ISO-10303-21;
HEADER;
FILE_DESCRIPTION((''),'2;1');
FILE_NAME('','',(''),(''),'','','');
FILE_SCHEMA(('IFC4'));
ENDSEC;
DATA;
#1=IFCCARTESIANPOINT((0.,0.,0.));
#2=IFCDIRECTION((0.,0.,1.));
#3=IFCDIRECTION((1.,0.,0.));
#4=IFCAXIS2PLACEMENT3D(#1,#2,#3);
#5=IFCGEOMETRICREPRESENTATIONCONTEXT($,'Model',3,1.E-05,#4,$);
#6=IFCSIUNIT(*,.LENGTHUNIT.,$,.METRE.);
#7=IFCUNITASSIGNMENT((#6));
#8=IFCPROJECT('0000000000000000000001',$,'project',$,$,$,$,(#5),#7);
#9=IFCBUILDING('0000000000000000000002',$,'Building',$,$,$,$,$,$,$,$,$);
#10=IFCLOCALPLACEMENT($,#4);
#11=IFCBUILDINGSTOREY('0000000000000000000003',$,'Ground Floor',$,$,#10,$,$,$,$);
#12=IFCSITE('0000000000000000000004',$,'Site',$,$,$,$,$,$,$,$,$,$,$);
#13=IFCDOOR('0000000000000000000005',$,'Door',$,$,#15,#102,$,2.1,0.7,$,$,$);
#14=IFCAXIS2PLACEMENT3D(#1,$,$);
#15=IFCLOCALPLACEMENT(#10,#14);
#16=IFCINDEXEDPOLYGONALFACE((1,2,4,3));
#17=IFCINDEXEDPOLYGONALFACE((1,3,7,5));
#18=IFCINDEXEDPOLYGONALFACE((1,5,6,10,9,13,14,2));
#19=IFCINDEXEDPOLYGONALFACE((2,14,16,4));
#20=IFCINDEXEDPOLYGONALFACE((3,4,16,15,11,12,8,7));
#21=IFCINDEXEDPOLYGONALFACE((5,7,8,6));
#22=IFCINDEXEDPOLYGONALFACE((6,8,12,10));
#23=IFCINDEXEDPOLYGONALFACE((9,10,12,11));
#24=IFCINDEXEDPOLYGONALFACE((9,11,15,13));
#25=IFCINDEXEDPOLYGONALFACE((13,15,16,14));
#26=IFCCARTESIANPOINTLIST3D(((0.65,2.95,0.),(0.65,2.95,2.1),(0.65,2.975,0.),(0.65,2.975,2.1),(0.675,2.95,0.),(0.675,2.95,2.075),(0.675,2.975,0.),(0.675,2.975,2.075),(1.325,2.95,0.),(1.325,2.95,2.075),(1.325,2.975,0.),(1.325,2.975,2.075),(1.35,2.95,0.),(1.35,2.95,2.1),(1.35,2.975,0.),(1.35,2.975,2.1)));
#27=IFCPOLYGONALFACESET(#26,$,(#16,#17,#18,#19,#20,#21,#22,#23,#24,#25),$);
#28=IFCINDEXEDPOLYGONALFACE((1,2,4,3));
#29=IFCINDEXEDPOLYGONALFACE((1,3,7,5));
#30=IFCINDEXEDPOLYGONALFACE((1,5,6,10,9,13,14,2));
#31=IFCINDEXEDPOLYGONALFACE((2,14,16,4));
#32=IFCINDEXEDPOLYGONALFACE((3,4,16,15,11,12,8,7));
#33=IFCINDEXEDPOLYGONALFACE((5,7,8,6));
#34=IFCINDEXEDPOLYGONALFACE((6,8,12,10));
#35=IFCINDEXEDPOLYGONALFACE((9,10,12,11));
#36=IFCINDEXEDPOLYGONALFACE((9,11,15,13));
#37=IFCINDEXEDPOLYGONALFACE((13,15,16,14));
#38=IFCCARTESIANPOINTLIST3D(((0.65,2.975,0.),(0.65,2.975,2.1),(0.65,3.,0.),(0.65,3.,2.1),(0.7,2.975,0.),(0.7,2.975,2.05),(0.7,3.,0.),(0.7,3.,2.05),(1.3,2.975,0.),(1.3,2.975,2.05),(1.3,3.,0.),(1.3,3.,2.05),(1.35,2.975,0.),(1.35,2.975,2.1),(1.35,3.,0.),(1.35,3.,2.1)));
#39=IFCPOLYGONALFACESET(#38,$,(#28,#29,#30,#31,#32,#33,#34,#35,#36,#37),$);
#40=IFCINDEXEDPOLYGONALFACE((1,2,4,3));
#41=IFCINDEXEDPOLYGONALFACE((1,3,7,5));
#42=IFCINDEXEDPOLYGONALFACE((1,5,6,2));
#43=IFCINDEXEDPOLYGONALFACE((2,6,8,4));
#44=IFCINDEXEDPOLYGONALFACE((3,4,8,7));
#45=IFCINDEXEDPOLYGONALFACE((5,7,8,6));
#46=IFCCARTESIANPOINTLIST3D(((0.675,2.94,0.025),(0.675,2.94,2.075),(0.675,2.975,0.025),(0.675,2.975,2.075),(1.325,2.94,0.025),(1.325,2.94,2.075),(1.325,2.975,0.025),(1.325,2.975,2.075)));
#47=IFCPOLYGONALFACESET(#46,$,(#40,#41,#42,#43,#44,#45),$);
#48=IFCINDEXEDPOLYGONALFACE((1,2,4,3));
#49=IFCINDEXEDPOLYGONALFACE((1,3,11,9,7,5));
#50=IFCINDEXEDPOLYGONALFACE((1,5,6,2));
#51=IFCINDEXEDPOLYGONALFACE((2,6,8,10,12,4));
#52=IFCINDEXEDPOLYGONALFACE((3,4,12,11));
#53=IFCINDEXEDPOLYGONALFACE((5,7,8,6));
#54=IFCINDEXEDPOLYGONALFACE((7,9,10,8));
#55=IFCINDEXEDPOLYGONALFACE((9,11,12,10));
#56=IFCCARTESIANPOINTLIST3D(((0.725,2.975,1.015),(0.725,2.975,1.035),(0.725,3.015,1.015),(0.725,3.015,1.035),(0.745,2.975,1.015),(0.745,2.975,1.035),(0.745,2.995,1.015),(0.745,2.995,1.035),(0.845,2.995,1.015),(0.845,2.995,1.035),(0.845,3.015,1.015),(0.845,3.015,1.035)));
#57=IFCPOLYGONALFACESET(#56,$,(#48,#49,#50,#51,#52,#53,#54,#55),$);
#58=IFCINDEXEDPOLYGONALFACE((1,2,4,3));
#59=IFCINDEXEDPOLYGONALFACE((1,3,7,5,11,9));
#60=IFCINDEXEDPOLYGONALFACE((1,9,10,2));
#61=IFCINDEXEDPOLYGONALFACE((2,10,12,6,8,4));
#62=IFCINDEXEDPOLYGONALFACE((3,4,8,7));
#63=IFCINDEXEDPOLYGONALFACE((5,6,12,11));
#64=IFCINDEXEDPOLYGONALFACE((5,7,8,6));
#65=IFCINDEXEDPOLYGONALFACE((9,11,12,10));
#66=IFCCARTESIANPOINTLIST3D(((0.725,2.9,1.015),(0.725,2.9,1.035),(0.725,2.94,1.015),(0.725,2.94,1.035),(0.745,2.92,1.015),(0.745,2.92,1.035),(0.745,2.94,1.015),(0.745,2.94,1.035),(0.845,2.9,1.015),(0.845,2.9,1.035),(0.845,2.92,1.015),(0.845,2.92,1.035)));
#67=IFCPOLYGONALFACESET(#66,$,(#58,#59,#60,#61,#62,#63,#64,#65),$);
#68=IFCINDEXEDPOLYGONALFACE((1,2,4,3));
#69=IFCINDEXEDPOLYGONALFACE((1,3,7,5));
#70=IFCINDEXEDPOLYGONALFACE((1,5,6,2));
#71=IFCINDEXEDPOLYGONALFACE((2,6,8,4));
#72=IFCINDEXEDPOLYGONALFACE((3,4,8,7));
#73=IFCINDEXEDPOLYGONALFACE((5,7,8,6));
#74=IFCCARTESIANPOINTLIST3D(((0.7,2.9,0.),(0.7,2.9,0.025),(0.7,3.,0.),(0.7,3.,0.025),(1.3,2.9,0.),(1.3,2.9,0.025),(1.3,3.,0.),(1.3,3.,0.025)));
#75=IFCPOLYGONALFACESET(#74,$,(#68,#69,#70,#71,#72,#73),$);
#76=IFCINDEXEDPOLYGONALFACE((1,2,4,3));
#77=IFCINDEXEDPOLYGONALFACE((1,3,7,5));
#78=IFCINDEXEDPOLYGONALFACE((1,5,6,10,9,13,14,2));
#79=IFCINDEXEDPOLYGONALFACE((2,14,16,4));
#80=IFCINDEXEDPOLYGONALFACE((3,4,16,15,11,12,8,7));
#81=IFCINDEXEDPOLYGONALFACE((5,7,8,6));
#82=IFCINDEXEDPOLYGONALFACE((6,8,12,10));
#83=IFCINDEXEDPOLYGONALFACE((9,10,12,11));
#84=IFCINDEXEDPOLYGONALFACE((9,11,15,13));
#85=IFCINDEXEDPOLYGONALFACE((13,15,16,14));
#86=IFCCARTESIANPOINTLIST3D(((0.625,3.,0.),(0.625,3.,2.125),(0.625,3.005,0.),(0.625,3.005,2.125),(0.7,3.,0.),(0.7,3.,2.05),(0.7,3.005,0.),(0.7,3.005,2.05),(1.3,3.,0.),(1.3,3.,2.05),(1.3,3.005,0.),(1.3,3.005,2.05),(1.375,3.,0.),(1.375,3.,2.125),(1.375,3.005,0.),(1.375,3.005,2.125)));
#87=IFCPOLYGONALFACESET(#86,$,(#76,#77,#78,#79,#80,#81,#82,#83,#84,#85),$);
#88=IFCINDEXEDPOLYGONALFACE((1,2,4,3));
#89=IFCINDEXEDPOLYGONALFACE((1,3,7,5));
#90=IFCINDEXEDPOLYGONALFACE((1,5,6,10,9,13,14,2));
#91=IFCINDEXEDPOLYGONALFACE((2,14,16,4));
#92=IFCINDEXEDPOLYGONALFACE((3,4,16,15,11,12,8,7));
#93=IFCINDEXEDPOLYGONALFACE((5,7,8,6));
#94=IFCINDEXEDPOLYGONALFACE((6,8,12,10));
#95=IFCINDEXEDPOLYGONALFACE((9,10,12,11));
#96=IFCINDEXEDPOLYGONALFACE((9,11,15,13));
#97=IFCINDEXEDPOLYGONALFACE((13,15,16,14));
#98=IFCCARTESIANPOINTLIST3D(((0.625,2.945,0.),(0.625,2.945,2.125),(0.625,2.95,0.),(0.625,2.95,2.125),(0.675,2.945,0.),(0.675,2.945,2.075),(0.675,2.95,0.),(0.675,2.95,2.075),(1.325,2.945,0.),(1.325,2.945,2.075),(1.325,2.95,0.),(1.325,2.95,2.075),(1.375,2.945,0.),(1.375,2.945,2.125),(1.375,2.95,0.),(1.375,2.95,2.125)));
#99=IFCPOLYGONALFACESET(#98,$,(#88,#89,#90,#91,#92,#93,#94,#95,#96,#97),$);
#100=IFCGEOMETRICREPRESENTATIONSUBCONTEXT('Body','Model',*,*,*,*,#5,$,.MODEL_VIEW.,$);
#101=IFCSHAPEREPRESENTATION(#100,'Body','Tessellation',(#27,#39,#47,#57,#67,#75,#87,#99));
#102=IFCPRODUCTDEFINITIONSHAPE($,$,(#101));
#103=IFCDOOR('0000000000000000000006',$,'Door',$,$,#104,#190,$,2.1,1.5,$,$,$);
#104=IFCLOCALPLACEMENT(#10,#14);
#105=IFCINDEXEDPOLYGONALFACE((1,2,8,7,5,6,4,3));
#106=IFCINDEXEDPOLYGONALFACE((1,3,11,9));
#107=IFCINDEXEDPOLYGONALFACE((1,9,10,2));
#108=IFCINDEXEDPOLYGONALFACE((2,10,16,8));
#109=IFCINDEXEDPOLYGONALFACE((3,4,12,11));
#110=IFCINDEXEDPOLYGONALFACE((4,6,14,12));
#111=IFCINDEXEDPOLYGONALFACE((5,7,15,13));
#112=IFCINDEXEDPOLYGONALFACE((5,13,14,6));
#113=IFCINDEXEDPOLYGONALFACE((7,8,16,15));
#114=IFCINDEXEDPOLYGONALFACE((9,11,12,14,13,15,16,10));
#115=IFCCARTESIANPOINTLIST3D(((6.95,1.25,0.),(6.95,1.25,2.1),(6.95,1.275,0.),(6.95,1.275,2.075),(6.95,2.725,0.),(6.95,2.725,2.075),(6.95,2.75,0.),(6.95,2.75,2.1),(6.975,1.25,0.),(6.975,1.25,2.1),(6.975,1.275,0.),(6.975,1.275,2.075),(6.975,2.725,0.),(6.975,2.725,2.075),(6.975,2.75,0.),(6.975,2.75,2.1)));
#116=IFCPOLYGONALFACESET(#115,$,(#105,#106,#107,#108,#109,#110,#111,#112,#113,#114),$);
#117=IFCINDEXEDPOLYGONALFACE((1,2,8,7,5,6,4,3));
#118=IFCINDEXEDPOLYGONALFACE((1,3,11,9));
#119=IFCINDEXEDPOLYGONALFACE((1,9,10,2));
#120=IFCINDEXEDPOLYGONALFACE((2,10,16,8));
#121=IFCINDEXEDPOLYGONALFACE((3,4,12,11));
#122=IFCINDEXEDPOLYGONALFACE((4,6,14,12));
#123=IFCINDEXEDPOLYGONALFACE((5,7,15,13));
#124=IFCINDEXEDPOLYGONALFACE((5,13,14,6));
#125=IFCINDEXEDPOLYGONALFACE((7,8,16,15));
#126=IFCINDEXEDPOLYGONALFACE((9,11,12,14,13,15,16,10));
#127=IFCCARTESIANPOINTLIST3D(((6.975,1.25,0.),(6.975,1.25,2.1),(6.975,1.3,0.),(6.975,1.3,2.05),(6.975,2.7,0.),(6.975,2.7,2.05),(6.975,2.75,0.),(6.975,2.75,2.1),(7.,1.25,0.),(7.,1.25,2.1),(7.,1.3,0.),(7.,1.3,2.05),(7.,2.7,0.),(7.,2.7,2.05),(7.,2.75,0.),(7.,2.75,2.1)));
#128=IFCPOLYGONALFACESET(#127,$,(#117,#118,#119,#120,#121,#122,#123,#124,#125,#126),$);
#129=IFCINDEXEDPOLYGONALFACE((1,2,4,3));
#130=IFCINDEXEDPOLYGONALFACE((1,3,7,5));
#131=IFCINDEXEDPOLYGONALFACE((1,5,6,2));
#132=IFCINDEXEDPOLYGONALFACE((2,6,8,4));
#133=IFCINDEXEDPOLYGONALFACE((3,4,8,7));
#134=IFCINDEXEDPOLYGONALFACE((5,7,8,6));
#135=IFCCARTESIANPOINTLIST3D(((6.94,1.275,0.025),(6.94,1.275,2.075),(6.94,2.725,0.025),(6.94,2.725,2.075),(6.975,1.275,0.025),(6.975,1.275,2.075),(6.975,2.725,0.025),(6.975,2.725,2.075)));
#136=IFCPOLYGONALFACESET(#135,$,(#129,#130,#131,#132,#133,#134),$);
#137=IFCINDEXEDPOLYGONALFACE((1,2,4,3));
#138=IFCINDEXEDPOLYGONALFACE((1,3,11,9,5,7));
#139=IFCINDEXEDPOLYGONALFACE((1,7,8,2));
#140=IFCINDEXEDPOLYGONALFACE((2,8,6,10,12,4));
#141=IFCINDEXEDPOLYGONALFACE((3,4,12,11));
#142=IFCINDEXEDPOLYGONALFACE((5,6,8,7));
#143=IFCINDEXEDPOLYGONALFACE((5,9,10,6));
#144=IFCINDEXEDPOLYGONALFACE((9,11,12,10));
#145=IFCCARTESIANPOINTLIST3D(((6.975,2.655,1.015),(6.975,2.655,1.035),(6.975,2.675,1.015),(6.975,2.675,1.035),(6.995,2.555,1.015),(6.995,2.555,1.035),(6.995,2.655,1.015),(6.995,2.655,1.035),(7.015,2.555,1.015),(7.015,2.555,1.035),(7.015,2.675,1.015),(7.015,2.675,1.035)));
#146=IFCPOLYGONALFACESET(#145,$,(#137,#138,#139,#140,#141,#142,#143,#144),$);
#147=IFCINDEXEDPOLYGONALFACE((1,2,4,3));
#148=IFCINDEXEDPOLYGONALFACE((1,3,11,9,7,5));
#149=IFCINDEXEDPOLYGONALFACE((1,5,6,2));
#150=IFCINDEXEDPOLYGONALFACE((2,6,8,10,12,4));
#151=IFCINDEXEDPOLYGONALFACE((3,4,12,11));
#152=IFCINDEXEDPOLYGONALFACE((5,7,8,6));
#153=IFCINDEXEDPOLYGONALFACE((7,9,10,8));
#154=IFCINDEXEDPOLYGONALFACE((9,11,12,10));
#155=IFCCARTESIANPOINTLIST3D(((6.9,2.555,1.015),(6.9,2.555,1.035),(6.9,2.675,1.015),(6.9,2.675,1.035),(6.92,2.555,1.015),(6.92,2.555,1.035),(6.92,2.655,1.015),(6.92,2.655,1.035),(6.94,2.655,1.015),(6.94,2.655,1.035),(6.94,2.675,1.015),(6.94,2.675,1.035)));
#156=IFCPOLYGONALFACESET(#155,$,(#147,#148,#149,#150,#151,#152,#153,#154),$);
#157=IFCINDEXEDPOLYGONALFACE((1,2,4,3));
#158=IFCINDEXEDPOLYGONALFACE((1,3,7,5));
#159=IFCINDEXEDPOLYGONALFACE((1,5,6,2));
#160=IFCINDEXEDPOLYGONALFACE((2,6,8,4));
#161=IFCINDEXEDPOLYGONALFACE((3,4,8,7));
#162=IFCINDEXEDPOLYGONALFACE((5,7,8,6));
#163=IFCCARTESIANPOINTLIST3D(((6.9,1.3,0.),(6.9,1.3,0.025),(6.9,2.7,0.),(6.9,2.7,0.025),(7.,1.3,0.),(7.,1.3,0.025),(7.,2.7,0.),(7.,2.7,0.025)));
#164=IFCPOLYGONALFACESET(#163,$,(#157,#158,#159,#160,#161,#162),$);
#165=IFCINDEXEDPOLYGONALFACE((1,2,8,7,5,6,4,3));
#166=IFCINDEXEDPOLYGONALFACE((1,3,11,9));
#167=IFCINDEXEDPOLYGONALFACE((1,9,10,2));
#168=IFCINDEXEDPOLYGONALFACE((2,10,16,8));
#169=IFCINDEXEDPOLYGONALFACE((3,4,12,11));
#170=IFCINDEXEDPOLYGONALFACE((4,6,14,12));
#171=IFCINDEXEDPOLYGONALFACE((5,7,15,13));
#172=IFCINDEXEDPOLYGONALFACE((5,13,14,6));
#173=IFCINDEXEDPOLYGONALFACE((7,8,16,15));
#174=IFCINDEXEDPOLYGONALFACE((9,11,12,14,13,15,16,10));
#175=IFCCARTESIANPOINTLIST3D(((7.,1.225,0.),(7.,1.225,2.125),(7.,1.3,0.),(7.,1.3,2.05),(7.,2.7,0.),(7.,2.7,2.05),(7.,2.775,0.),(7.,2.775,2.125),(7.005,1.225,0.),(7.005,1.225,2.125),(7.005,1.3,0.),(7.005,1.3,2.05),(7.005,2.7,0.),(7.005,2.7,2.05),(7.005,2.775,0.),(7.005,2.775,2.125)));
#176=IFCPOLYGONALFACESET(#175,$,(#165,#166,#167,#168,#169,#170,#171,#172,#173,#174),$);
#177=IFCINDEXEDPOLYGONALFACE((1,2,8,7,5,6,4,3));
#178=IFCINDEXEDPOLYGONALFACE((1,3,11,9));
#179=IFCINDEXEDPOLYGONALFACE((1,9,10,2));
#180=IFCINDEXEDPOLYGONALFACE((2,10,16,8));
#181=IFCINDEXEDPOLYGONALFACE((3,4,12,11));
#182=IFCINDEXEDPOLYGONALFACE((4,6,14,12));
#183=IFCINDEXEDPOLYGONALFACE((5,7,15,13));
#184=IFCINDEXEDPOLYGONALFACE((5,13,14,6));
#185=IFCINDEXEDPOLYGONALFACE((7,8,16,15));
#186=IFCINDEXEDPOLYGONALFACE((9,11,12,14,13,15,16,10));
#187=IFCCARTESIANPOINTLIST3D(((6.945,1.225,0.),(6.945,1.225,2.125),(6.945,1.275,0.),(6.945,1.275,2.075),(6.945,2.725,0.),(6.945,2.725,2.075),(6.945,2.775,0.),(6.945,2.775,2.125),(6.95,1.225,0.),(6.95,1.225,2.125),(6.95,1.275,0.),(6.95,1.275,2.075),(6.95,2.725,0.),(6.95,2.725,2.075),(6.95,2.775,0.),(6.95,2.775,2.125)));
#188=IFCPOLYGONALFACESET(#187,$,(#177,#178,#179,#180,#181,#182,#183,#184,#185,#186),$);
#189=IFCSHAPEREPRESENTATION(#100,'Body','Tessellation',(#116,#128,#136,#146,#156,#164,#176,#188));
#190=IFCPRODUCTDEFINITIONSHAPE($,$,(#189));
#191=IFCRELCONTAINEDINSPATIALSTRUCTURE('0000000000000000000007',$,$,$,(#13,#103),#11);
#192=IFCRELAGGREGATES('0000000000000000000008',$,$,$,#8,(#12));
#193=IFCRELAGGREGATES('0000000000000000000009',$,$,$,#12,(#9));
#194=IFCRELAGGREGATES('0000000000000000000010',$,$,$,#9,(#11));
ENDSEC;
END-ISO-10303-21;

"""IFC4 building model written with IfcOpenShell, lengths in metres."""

from ifc_helpers import new_model, si_unit, frame, origin_with_axes, place, context, subcontext, project, spatial, line, indexed_curve, outline, extrude, element, save


model = new_model("IFC4")

# Units and contexts
model_context = context("Model", 3, precision=1e-05, world=origin_with_axes())
body_context = subcontext(model_context, "Body", "Model", "MODEL_VIEW")
ifc_project = project(units=[si_unit("LENGTHUNIT", "METRE")], contexts=[model_context])

# Site, building, storey
site = spatial("IfcSite", under=ifc_project, Name="Site")
building = spatial("IfcBuilding", under=site, Name="Building")
storey_placement = place(None, origin_with_axes())
storey = spatial("IfcBuildingStorey", under=building, at=storey_placement, Name="Ground Floor")

# Doors
door_1_placement = place(storey_placement, frame((1.35, 3.0, 0.0), z_axis=(0.0, 0.0, 1.0), x_axis=(-1.0, 0.0, 0.0)))
element("IfcDoor", 1, at=door_1_placement, inside=storey, Name="Door", OverallHeight=2.1, OverallWidth=0.7, context=body_context, shape_type="SweptSolid", body=[
    extrude(outline(indexed_curve([(0.0, 0.0), (0.0, 2.1), (0.7, 2.1), (0.7, 0.0), (0.675, 0.0), (0.675, 2.075), (0.025, 2.075), (0.025, 0.0)], segments=[line(1, 2, 3, 4, 5, 6, 7, 8, 1)])), frame((0.0, 0.025, 0.0), z_axis=(0.0, -1.0, 0.0), x_axis=(1.0, 0.0, 0.0)), (0.0, 0.0, -1.0), 0.025),
    extrude(outline(indexed_curve([(0.0, 0.0), (0.0, 2.1), (0.7, 2.1), (0.7, 0.0), (0.65, 0.0), (0.65, 2.05), (0.05, 2.05), (0.05, 0.0)], segments=[line(1, 2, 3, 4, 5, 6, 7, 8, 1)])), frame((0.0, 0.0, 0.0), z_axis=(0.0, -1.0, 0.0), x_axis=(1.0, 0.0, 0.0)), (0.0, 0.0, -1.0), 0.025),
    extrude(outline(indexed_curve([(0.0, 0.0), (0.65, 0.0), (0.65, 0.035), (0.0, 0.035)], segments=[line(1, 2, 3, 4, 1)])), frame((0.025, 0.025, 0.025), z_axis=(0.0, 0.0, 1.0), x_axis=(1.0, 0.0, 0.0)), (0.0, 0.0, 1.0), 2.05),
    extrude(outline(indexed_curve([(0.0, 0.0), (0.0, -0.04), (-0.12, -0.04), (-0.12, -0.02), (-0.02, -0.02), (-0.02, 0.0)], segments=[line(1, 2, 3, 4, 5, 6, 1)])), frame((0.625, 0.025, 1.015), z_axis=(0.0, 0.0, 1.0), x_axis=(1.0, 0.0, 0.0)), (0.0, 0.0, 1.0), 0.02),
    extrude(outline(indexed_curve([(0.0, 0.0), (0.0, 0.04), (-0.12, 0.04), (-0.12, 0.02), (-0.02, 0.02), (-0.02, 0.0)], segments=[line(1, 2, 3, 4, 5, 6, 1)])), frame((0.625, 0.06, 1.015), z_axis=(0.0, 0.0, 1.0), x_axis=(1.0, 0.0, 0.0)), (0.0, 0.0, 1.0), 0.02),
    extrude(outline(indexed_curve([(0.0, 0.0), (0.6, 0.0), (0.6, 0.1), (0.0, 0.1)], segments=[line(1, 2, 3, 4, 1)])), frame((0.05, 0.0, 0.0), z_axis=(0.0, 0.0, 1.0), x_axis=(1.0, 0.0, 0.0)), (0.0, 0.0, 1.0), 0.025),
    extrude(outline(indexed_curve([(0.0, 0.0), (0.0, 2.125), (0.75, 2.125), (0.75, 0.0), (0.675, 0.0), (0.675, 2.05), (0.075, 2.05), (0.075, 0.0)], segments=[line(1, 2, 3, 4, 5, 6, 7, 8, 1)])), frame((-0.025, -0.005, 0.0), z_axis=(0.0, -1.0, 0.0), x_axis=(1.0, 0.0, 0.0)), (0.0, 0.0, -1.0), 0.005),
    extrude(outline(indexed_curve([(0.0, 0.0), (0.0, 2.125), (0.75, 2.125), (0.75, 0.0), (0.7, 0.0), (0.7, 2.075), (0.05, 2.075), (0.05, 0.0)], segments=[line(1, 2, 3, 4, 5, 6, 7, 8, 1)])), frame((-0.025, 0.05, 0.0), z_axis=(0.0, -1.0, 0.0), x_axis=(1.0, 0.0, 0.0)), (0.0, 0.0, -1.0), 0.005),
])
door_2_placement = place(storey_placement, frame((7.0, 1.25, 0.0), z_axis=(0.0, 0.0, 1.0), x_axis=(0.0, 1.0, 0.0)))
element("IfcDoor", 2, at=door_2_placement, inside=storey, Name="Door", OverallHeight=2.1, OverallWidth=1.5, context=body_context, shape_type="SweptSolid", body=[
    extrude(outline(indexed_curve([(0.0, 0.0), (0.0, 2.1), (1.5, 2.1), (1.5, 0.0), (1.475, 0.0), (1.475, 2.075), (0.025, 2.075), (0.025, 0.0)], segments=[line(1, 2, 3, 4, 5, 6, 7, 8, 1)])), frame((0.0, 0.025, 0.0), z_axis=(0.0, -1.0, 0.0), x_axis=(1.0, 0.0, 0.0)), (0.0, 0.0, -1.0), 0.025),
    extrude(outline(indexed_curve([(0.0, 0.0), (0.0, 2.1), (1.5, 2.1), (1.5, 0.0), (1.45, 0.0), (1.45, 2.05), (0.05, 2.05), (0.05, 0.0)], segments=[line(1, 2, 3, 4, 5, 6, 7, 8, 1)])), frame((0.0, 0.0, 0.0), z_axis=(0.0, -1.0, 0.0), x_axis=(1.0, 0.0, 0.0)), (0.0, 0.0, -1.0), 0.025),
    extrude(outline(indexed_curve([(0.0, 0.0), (1.45, 0.0), (1.45, 0.035), (0.0, 0.035)], segments=[line(1, 2, 3, 4, 1)])), frame((0.025, 0.025, 0.025), z_axis=(0.0, 0.0, 1.0), x_axis=(1.0, 0.0, 0.0)), (0.0, 0.0, 1.0), 2.05),
    extrude(outline(indexed_curve([(0.0, 0.0), (0.0, -0.04), (-0.12, -0.04), (-0.12, -0.02), (-0.02, -0.02), (-0.02, 0.0)], segments=[line(1, 2, 3, 4, 5, 6, 1)])), frame((1.425, 0.025, 1.015), z_axis=(0.0, 0.0, 1.0), x_axis=(1.0, 0.0, 0.0)), (0.0, 0.0, 1.0), 0.02),
    extrude(outline(indexed_curve([(0.0, 0.0), (0.0, 0.04), (-0.12, 0.04), (-0.12, 0.02), (-0.02, 0.02), (-0.02, 0.0)], segments=[line(1, 2, 3, 4, 5, 6, 1)])), frame((1.425, 0.06, 1.015), z_axis=(0.0, 0.0, 1.0), x_axis=(1.0, 0.0, 0.0)), (0.0, 0.0, 1.0), 0.02),
    extrude(outline(indexed_curve([(0.0, 0.0), (1.4, 0.0), (1.4, 0.1), (0.0, 0.1)], segments=[line(1, 2, 3, 4, 1)])), frame((0.05, 0.0, 0.0), z_axis=(0.0, 0.0, 1.0), x_axis=(1.0, 0.0, 0.0)), (0.0, 0.0, 1.0), 0.025),
    extrude(outline(indexed_curve([(0.0, 0.0), (0.0, 2.125), (1.55, 2.125), (1.55, 0.0), (1.475, 0.0), (1.475, 2.05), (0.075, 2.05), (0.075, 0.0)], segments=[line(1, 2, 3, 4, 5, 6, 7, 8, 1)])), frame((-0.025, -0.005, 0.0), z_axis=(0.0, -1.0, 0.0), x_axis=(1.0, 0.0, 0.0)), (0.0, 0.0, -1.0), 0.005),
    extrude(outline(indexed_curve([(0.0, 0.0), (0.0, 2.125), (1.55, 2.125), (1.55, 0.0), (1.5, 0.0), (1.5, 2.075), (0.05, 2.075), (0.05, 0.0)], segments=[line(1, 2, 3, 4, 5, 6, 7, 8, 1)])), frame((-0.025, 0.05, 0.0), z_axis=(0.0, -1.0, 0.0), x_axis=(1.0, 0.0, 0.0)), (0.0, 0.0, -1.0), 0.005),
])

save(model, "model.ifc")
